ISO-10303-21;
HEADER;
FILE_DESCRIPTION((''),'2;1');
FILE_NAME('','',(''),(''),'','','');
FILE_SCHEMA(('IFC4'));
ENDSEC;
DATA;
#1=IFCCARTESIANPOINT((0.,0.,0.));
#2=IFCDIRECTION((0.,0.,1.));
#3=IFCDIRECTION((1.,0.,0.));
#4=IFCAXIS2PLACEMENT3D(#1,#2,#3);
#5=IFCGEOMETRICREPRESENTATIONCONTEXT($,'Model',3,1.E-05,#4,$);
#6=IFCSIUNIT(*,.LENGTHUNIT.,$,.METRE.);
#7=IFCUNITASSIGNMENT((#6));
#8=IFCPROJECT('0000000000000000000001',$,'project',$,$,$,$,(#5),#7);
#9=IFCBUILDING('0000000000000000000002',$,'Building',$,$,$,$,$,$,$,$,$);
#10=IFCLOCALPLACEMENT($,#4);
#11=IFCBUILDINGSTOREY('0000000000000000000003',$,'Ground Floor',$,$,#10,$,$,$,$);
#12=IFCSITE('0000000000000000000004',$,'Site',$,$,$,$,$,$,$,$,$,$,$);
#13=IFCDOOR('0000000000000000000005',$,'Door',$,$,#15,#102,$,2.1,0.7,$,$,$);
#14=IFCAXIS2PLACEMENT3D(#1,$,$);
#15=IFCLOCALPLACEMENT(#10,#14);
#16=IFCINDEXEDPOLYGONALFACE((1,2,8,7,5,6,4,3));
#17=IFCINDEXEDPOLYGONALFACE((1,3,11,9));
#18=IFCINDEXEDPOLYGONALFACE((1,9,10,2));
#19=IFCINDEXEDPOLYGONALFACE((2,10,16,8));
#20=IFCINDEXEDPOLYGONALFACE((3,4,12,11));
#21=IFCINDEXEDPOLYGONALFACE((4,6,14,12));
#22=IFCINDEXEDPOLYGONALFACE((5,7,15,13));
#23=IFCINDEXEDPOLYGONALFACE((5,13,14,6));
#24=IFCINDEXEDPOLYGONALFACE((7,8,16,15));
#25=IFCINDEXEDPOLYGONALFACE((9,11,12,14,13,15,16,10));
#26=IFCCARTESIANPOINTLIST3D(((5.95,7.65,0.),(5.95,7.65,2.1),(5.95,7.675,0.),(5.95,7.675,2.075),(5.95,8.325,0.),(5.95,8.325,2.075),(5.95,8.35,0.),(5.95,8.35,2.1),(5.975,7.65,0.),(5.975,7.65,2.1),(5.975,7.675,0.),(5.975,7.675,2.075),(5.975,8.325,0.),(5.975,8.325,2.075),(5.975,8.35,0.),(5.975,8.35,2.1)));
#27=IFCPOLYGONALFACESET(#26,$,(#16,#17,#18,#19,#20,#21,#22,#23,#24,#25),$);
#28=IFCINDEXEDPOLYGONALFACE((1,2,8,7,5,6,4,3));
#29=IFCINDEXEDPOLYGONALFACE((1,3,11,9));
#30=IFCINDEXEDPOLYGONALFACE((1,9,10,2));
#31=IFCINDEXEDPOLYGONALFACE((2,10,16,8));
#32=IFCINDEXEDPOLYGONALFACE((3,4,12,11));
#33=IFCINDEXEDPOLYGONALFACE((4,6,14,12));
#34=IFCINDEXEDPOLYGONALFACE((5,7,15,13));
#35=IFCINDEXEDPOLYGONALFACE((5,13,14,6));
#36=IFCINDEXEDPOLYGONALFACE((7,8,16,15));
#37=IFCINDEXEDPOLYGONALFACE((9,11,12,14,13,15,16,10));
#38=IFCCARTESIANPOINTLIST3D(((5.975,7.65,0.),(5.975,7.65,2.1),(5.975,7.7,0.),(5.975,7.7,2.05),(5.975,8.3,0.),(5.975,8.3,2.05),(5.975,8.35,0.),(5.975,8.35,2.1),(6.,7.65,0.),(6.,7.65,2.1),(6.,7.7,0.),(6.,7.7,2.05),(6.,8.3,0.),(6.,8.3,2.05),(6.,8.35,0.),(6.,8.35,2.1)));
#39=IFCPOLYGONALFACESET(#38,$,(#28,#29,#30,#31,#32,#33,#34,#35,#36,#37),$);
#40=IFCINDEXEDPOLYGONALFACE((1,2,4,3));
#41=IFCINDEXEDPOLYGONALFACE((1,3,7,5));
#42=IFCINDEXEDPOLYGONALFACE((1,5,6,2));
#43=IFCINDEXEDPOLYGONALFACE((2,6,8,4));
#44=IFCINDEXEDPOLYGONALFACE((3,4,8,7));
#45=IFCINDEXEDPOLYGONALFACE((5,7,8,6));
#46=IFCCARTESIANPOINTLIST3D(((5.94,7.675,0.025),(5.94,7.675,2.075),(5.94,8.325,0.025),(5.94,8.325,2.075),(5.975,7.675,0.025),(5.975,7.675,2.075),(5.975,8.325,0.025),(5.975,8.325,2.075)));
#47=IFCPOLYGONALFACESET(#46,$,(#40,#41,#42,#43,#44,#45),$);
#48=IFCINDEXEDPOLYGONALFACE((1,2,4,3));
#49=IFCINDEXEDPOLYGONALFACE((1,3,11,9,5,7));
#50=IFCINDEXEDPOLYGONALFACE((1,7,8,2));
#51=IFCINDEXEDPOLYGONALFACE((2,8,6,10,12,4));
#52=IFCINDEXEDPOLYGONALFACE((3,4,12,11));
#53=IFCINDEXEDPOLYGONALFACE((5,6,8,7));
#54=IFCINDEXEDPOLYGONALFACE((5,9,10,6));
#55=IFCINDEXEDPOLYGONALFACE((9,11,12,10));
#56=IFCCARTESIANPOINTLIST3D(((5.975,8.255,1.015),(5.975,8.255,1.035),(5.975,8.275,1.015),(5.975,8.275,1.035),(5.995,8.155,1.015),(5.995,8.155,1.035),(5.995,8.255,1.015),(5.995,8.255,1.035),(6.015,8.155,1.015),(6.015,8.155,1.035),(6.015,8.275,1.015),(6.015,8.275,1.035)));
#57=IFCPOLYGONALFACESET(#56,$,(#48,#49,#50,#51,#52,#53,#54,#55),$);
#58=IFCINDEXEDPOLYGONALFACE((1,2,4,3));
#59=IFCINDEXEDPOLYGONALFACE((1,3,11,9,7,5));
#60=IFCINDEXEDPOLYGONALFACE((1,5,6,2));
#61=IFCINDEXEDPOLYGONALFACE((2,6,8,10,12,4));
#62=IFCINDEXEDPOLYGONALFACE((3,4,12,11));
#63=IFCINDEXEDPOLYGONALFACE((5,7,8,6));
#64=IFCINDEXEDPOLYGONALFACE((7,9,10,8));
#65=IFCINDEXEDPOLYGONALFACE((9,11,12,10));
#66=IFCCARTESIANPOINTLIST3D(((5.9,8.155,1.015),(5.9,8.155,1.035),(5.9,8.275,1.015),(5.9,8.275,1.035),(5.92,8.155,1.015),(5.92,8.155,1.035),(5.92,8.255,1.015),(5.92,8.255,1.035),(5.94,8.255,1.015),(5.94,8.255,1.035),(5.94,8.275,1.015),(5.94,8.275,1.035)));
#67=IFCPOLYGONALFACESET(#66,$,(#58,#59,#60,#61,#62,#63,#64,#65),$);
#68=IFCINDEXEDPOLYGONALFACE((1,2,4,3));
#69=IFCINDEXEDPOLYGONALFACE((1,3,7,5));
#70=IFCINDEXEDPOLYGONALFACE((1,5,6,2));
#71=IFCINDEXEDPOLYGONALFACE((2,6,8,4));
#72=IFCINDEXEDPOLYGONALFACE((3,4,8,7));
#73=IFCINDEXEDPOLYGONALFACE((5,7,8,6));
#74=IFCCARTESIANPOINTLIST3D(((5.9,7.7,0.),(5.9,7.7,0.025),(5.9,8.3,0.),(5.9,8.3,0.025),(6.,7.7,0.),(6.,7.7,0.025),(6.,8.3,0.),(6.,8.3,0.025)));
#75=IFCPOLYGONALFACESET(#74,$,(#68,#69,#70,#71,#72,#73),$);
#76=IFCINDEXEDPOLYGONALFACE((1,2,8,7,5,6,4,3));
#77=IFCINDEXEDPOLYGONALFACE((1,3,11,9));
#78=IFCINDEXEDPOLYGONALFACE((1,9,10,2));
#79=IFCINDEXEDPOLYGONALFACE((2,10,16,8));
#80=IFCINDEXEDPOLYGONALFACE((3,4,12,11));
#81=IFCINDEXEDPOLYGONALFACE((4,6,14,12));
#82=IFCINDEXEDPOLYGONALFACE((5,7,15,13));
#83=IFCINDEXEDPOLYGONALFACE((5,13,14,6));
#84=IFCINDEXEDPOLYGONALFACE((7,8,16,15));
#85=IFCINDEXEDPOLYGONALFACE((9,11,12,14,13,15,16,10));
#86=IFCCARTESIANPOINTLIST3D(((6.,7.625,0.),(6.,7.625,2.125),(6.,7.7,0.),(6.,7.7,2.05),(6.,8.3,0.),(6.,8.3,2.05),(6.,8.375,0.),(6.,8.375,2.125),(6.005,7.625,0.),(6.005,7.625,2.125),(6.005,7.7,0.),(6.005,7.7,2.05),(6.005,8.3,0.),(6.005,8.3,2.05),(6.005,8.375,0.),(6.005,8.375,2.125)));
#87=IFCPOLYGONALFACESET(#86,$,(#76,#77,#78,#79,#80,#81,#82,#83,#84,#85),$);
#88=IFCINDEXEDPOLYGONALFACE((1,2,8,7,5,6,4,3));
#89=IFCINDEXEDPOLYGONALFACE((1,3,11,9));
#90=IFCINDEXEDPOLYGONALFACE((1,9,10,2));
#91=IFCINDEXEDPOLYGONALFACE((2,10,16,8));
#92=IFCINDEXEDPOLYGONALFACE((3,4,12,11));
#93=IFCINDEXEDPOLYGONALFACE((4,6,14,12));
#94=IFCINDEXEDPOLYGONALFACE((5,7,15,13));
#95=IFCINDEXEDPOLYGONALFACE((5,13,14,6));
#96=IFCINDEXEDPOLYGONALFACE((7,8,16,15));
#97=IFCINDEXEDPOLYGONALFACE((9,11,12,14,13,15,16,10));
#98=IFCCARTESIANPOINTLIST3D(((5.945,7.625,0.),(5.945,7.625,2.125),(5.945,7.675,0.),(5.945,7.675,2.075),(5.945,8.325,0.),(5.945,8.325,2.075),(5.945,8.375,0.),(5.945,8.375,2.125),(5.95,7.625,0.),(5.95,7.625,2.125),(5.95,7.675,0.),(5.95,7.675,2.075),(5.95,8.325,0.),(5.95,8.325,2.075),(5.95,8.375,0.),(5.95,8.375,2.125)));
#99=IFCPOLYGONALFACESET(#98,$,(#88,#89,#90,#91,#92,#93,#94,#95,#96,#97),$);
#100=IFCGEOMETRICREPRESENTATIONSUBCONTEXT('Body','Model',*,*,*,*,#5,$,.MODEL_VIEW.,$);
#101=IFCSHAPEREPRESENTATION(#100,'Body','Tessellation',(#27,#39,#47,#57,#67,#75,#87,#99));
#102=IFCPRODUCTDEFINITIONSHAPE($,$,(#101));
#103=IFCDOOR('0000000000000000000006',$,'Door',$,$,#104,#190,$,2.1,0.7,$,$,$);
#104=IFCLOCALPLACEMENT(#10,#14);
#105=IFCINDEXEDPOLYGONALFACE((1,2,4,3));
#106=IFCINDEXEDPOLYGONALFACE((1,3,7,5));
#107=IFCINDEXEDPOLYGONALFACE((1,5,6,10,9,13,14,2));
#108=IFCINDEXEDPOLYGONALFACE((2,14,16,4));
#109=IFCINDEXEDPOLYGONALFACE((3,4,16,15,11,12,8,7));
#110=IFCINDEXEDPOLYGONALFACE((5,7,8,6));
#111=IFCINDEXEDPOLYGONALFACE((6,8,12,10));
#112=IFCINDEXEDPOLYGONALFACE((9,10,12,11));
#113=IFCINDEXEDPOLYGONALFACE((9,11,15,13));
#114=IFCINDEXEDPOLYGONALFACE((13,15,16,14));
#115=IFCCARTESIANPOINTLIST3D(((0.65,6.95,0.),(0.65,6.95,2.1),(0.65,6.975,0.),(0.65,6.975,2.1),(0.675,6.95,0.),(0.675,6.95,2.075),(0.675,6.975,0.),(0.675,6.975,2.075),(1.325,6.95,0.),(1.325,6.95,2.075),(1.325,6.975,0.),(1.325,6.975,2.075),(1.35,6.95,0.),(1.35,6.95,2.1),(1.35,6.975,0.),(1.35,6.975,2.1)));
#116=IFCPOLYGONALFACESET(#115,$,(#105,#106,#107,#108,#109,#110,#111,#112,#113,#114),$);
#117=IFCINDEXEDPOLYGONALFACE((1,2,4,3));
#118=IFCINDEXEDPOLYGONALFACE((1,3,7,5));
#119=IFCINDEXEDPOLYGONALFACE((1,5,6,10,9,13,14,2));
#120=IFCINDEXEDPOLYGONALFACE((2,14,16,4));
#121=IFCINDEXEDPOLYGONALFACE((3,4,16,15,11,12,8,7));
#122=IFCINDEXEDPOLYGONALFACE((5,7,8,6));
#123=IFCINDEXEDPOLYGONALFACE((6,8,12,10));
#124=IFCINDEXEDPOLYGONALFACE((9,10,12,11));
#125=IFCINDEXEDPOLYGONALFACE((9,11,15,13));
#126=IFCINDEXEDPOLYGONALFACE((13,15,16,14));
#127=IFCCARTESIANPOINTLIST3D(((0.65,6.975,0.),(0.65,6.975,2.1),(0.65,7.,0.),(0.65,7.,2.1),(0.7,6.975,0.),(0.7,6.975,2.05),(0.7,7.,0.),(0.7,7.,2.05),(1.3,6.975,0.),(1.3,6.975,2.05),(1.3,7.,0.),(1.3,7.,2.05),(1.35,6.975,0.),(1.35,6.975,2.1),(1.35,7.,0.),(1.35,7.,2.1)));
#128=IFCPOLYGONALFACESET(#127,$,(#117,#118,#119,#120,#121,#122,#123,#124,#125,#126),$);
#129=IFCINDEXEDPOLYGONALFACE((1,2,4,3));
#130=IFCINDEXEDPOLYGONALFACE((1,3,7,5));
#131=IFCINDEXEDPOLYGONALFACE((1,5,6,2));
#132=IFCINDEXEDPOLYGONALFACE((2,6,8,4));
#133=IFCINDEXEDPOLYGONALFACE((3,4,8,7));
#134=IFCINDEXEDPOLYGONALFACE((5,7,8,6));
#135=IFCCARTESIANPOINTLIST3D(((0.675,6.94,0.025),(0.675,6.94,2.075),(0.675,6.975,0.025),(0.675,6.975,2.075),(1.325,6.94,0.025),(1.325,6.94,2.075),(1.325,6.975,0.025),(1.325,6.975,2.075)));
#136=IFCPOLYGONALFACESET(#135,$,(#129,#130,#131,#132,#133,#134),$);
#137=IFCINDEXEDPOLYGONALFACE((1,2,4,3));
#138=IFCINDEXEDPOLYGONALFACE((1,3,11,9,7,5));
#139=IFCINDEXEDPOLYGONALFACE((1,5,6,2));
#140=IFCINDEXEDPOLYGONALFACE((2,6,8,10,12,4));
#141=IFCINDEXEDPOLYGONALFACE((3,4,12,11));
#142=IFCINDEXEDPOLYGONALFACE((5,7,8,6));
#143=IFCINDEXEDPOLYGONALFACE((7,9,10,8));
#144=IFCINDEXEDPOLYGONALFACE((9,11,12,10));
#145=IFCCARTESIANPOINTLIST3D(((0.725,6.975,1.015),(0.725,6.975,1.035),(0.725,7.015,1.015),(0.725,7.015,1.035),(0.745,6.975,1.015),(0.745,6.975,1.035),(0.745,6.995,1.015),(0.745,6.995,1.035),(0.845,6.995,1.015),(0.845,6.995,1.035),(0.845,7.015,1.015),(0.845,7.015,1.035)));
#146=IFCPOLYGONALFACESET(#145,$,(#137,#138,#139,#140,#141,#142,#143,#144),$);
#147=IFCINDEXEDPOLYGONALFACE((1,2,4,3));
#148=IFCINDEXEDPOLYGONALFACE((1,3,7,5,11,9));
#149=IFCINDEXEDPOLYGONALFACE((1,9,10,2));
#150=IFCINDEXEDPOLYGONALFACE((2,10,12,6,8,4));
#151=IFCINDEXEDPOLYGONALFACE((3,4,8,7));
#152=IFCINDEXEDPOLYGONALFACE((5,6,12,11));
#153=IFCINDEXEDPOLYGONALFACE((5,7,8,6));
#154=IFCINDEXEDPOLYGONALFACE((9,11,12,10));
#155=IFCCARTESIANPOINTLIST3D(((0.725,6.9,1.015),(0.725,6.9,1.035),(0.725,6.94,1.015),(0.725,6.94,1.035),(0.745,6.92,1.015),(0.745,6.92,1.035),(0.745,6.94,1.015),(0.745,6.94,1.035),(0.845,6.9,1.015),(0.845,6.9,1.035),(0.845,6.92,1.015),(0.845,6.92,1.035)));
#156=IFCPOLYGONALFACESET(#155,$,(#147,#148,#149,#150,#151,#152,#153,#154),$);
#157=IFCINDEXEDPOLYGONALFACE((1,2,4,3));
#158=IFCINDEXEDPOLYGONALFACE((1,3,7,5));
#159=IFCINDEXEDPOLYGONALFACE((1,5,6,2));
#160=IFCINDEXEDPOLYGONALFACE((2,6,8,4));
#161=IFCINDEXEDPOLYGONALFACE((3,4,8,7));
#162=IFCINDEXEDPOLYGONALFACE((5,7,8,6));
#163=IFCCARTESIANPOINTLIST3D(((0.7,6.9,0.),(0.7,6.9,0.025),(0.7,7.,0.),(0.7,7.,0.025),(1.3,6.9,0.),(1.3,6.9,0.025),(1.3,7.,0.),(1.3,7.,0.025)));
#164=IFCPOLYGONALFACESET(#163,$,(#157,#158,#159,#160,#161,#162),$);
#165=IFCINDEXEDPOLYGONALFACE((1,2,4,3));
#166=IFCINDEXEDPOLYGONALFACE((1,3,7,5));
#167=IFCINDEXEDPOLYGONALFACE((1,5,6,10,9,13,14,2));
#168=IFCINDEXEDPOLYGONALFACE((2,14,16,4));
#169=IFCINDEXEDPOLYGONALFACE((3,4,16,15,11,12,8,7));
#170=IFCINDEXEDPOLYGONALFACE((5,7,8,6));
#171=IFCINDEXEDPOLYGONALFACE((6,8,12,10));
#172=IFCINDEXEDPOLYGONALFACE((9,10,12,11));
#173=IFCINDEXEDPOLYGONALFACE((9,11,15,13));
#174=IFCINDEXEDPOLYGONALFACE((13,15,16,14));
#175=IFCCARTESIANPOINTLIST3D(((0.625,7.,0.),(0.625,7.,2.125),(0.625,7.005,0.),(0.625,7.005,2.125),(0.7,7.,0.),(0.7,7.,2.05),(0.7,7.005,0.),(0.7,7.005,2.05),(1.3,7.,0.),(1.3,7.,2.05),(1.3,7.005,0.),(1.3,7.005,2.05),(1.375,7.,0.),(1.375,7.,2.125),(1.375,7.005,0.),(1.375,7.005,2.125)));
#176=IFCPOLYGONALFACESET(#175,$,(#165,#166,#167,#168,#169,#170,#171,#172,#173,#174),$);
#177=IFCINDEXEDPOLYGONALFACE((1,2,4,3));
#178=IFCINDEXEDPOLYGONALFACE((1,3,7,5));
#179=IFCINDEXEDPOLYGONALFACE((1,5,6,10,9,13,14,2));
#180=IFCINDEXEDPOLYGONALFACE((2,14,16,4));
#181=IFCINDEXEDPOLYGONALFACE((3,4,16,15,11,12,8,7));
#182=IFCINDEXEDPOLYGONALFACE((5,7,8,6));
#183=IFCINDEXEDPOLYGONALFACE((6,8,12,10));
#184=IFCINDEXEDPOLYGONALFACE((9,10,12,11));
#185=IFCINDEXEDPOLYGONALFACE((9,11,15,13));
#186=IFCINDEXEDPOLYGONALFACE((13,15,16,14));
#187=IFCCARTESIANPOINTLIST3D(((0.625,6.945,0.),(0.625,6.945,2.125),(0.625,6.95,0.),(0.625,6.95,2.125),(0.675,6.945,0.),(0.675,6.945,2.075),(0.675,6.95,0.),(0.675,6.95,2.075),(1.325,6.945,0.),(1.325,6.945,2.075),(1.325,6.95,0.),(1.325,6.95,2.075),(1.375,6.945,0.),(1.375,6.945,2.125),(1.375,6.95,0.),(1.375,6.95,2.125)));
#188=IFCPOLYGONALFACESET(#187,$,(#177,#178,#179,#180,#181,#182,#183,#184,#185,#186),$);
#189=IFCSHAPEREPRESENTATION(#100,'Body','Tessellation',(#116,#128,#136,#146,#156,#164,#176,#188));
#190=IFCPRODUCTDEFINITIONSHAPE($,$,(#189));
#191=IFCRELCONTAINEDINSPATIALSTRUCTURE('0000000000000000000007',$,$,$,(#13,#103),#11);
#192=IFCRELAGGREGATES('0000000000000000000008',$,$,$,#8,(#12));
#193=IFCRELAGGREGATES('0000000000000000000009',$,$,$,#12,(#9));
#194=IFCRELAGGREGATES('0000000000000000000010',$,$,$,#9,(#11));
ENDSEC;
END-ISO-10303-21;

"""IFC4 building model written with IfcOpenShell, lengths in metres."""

from ifc_helpers import new_model, si_unit, frame, origin_with_axes, place, context, subcontext, project, spatial, line, indexed_curve, outline, extrude, element, save


model = new_model("IFC4")

# Units and contexts
model_context = context("Model", 3, precision=1e-05, world=origin_with_axes())
body_context = subcontext(model_context, "Body", "Model", "MODEL_VIEW")
ifc_project = project(units=[si_unit("LENGTHUNIT", "METRE")], contexts=[model_context])

# Site, building, storey
site = spatial("IfcSite", under=ifc_project, Name="Site")
building = spatial("IfcBuilding", under=site, Name="Building")
storey_placement = place(None, origin_with_axes())
storey = spatial("IfcBuildingStorey", under=building, at=storey_placement, Name="Ground Floor")

# Doors
door_1_placement = place(storey_placement, frame((6.0, 7.65, 0.0), z_axis=(0.0, 0.0, 1.0), x_axis=(0.0, 1.0, 0.0)))
element("IfcDoor", 1, at=door_1_placement, inside=storey, Name="Door", OverallHeight=2.1, OverallWidth=0.7, context=body_context, shape_type="SweptSolid", body=[
    extrude(outline(indexed_curve([(0.0, 0.0), (0.0, 2.1), (0.7, 2.1), (0.7, 0.0), (0.675, 0.0), (0.675, 2.075), (0.025, 2.075), (0.025, 0.0)], segments=[line(1, 2, 3, 4, 5, 6, 7, 8, 1)])), frame((0.0, 0.025, 0.0), z_axis=(0.0, -1.0, 0.0), x_axis=(1.0, 0.0, 0.0)), (0.0, 0.0, -1.0), 0.025),
    extrude(outline(indexed_curve([(0.0, 0.0), (0.0, 2.1), (0.7, 2.1), (0.7, 0.0), (0.65, 0.0), (0.65, 2.05), (0.05, 2.05), (0.05, 0.0)], segments=[line(1, 2, 3, 4, 5, 6, 7, 8, 1)])), frame((0.0, 0.0, 0.0), z_axis=(0.0, -1.0, 0.0), x_axis=(1.0, 0.0, 0.0)), (0.0, 0.0, -1.0), 0.025),
    extrude(outline(indexed_curve([(0.0, 0.0), (0.65, 0.0), (0.65, 0.035), (0.0, 0.035)], segments=[line(1, 2, 3, 4, 1)])), frame((0.025, 0.025, 0.025), z_axis=(0.0, 0.0, 1.0), x_axis=(1.0, 0.0, 0.0)), (0.0, 0.0, 1.0), 2.05),
    extrude(outline(indexed_curve([(0.0, 0.0), (0.0, -0.04), (-0.12, -0.04), (-0.12, -0.02), (-0.02, -0.02), (-0.02, 0.0)], segments=[line(1, 2, 3, 4, 5, 6, 1)])), frame((0.625, 0.025, 1.015), z_axis=(0.0, 0.0, 1.0), x_axis=(1.0, 0.0, 0.0)), (0.0, 0.0, 1.0), 0.02),
    extrude(outline(indexed_curve([(0.0, 0.0), (0.0, 0.04), (-0.12, 0.04), (-0.12, 0.02), (-0.02, 0.02), (-0.02, 0.0)], segments=[line(1, 2, 3, 4, 5, 6, 1)])), frame((0.625, 0.06, 1.015), z_axis=(0.0, 0.0, 1.0), x_axis=(1.0, 0.0, 0.0)), (0.0, 0.0, 1.0), 0.02),
    extrude(outline(indexed_curve([(0.0, 0.0), (0.6, 0.0), (0.6, 0.1), (0.0, 0.1)], segments=[line(1, 2, 3, 4, 1)])), frame((0.05, 0.0, 0.0), z_axis=(0.0, 0.0, 1.0), x_axis=(1.0, 0.0, 0.0)), (0.0, 0.0, 1.0), 0.025),
    extrude(outline(indexed_curve([(0.0, 0.0), (0.0, 2.125), (0.75, 2.125), (0.75, 0.0), (0.675, 0.0), (0.675, 2.05), (0.075, 2.05), (0.075, 0.0)], segments=[line(1, 2, 3, 4, 5, 6, 7, 8, 1)])), frame((-0.025, -0.005, 0.0), z_axis=(0.0, -1.0, 0.0), x_axis=(1.0, 0.0, 0.0)), (0.0, 0.0, -1.0), 0.005),
    extrude(outline(indexed_curve([(0.0, 0.0), (0.0, 2.125), (0.75, 2.125), (0.75, 0.0), (0.7, 0.0), (0.7, 2.075), (0.05, 2.075), (0.05, 0.0)], segments=[line(1, 2, 3, 4, 5, 6, 7, 8, 1)])), frame((-0.025, 0.05, 0.0), z_axis=(0.0, -1.0, 0.0), x_axis=(1.0, 0.0, 0.0)), (0.0, 0.0, -1.0), 0.005),
])
door_2_placement = place(storey_placement, frame((1.35, 7.0, 0.0), z_axis=(0.0, 0.0, 1.0), x_axis=(-1.0, 0.0, 0.0)))
element("IfcDoor", 2, at=door_2_placement, inside=storey, Name="Door", OverallHeight=2.1, OverallWidth=0.7, context=body_context, shape_type="SweptSolid", body=[
    extrude(outline(indexed_curve([(0.0, 0.0), (0.0, 2.1), (0.7, 2.1), (0.7, 0.0), (0.675, 0.0), (0.675, 2.075), (0.025, 2.075), (0.025, 0.0)], segments=[line(1, 2, 3, 4, 5, 6, 7, 8, 1)])), frame((0.0, 0.025, 0.0), z_axis=(0.0, -1.0, 0.0), x_axis=(1.0, 0.0, 0.0)), (0.0, 0.0, -1.0), 0.025),
    extrude(outline(indexed_curve([(0.0, 0.0), (0.0, 2.1), (0.7, 2.1), (0.7, 0.0), (0.65, 0.0), (0.65, 2.05), (0.05, 2.05), (0.05, 0.0)], segments=[line(1, 2, 3, 4, 5, 6, 7, 8, 1)])), frame((0.0, 0.0, 0.0), z_axis=(0.0, -1.0, 0.0), x_axis=(1.0, 0.0, 0.0)), (0.0, 0.0, -1.0), 0.025),
    extrude(outline(indexed_curve([(0.0, 0.0), (0.65, 0.0), (0.65, 0.035), (0.0, 0.035)], segments=[line(1, 2, 3, 4, 1)])), frame((0.025, 0.025, 0.025), z_axis=(0.0, 0.0, 1.0), x_axis=(1.0, 0.0, 0.0)), (0.0, 0.0, 1.0), 2.05),
    extrude(outline(indexed_curve([(0.0, 0.0), (0.0, -0.04), (-0.12, -0.04), (-0.12, -0.02), (-0.02, -0.02), (-0.02, 0.0)], segments=[line(1, 2, 3, 4, 5, 6, 1)])), frame((0.625, 0.025, 1.015), z_axis=(0.0, 0.0, 1.0), x_axis=(1.0, 0.0, 0.0)), (0.0, 0.0, 1.0), 0.02),
    extrude(outline(indexed_curve([(0.0, 0.0), (0.0, 0.04), (-0.12, 0.04), (-0.12, 0.02), (-0.02, 0.02), (-0.02, 0.0)], segments=[line(1, 2, 3, 4, 5, 6, 1)])), frame((0.625, 0.06, 1.015), z_axis=(0.0, 0.0, 1.0), x_axis=(1.0, 0.0, 0.0)), (0.0, 0.0, 1.0), 0.02),
    extrude(outline(indexed_curve([(0.0, 0.0), (0.6, 0.0), (0.6, 0.1), (0.0, 0.1)], segments=[line(1, 2, 3, 4, 1)])), frame((0.05, 0.0, 0.0), z_axis=(0.0, 0.0, 1.0), x_axis=(1.0, 0.0, 0.0)), (0.0, 0.0, 1.0), 0.025),
    extrude(outline(indexed_curve([(0.0, 0.0), (0.0, 2.125), (0.75, 2.125), (0.75, 0.0), (0.675, 0.0), (0.675, 2.05), (0.075, 2.05), (0.075, 0.0)], segments=[line(1, 2, 3, 4, 5, 6, 7, 8, 1)])), frame((-0.025, -0.005, 0.0), z_axis=(0.0, -1.0, 0.0), x_axis=(1.0, 0.0, 0.0)), (0.0, 0.0, -1.0), 0.005),
    extrude(outline(indexed_curve([(0.0, 0.0), (0.0, 2.125), (0.75, 2.125), (0.75, 0.0), (0.7, 0.0), (0.7, 2.075), (0.05, 2.075), (0.05, 0.0)], segments=[line(1, 2, 3, 4, 5, 6, 7, 8, 1)])), frame((-0.025, 0.05, 0.0), z_axis=(0.0, -1.0, 0.0), x_axis=(1.0, 0.0, 0.0)), (0.0, 0.0, -1.0), 0.005),
])

save(model, "model.ifc")
